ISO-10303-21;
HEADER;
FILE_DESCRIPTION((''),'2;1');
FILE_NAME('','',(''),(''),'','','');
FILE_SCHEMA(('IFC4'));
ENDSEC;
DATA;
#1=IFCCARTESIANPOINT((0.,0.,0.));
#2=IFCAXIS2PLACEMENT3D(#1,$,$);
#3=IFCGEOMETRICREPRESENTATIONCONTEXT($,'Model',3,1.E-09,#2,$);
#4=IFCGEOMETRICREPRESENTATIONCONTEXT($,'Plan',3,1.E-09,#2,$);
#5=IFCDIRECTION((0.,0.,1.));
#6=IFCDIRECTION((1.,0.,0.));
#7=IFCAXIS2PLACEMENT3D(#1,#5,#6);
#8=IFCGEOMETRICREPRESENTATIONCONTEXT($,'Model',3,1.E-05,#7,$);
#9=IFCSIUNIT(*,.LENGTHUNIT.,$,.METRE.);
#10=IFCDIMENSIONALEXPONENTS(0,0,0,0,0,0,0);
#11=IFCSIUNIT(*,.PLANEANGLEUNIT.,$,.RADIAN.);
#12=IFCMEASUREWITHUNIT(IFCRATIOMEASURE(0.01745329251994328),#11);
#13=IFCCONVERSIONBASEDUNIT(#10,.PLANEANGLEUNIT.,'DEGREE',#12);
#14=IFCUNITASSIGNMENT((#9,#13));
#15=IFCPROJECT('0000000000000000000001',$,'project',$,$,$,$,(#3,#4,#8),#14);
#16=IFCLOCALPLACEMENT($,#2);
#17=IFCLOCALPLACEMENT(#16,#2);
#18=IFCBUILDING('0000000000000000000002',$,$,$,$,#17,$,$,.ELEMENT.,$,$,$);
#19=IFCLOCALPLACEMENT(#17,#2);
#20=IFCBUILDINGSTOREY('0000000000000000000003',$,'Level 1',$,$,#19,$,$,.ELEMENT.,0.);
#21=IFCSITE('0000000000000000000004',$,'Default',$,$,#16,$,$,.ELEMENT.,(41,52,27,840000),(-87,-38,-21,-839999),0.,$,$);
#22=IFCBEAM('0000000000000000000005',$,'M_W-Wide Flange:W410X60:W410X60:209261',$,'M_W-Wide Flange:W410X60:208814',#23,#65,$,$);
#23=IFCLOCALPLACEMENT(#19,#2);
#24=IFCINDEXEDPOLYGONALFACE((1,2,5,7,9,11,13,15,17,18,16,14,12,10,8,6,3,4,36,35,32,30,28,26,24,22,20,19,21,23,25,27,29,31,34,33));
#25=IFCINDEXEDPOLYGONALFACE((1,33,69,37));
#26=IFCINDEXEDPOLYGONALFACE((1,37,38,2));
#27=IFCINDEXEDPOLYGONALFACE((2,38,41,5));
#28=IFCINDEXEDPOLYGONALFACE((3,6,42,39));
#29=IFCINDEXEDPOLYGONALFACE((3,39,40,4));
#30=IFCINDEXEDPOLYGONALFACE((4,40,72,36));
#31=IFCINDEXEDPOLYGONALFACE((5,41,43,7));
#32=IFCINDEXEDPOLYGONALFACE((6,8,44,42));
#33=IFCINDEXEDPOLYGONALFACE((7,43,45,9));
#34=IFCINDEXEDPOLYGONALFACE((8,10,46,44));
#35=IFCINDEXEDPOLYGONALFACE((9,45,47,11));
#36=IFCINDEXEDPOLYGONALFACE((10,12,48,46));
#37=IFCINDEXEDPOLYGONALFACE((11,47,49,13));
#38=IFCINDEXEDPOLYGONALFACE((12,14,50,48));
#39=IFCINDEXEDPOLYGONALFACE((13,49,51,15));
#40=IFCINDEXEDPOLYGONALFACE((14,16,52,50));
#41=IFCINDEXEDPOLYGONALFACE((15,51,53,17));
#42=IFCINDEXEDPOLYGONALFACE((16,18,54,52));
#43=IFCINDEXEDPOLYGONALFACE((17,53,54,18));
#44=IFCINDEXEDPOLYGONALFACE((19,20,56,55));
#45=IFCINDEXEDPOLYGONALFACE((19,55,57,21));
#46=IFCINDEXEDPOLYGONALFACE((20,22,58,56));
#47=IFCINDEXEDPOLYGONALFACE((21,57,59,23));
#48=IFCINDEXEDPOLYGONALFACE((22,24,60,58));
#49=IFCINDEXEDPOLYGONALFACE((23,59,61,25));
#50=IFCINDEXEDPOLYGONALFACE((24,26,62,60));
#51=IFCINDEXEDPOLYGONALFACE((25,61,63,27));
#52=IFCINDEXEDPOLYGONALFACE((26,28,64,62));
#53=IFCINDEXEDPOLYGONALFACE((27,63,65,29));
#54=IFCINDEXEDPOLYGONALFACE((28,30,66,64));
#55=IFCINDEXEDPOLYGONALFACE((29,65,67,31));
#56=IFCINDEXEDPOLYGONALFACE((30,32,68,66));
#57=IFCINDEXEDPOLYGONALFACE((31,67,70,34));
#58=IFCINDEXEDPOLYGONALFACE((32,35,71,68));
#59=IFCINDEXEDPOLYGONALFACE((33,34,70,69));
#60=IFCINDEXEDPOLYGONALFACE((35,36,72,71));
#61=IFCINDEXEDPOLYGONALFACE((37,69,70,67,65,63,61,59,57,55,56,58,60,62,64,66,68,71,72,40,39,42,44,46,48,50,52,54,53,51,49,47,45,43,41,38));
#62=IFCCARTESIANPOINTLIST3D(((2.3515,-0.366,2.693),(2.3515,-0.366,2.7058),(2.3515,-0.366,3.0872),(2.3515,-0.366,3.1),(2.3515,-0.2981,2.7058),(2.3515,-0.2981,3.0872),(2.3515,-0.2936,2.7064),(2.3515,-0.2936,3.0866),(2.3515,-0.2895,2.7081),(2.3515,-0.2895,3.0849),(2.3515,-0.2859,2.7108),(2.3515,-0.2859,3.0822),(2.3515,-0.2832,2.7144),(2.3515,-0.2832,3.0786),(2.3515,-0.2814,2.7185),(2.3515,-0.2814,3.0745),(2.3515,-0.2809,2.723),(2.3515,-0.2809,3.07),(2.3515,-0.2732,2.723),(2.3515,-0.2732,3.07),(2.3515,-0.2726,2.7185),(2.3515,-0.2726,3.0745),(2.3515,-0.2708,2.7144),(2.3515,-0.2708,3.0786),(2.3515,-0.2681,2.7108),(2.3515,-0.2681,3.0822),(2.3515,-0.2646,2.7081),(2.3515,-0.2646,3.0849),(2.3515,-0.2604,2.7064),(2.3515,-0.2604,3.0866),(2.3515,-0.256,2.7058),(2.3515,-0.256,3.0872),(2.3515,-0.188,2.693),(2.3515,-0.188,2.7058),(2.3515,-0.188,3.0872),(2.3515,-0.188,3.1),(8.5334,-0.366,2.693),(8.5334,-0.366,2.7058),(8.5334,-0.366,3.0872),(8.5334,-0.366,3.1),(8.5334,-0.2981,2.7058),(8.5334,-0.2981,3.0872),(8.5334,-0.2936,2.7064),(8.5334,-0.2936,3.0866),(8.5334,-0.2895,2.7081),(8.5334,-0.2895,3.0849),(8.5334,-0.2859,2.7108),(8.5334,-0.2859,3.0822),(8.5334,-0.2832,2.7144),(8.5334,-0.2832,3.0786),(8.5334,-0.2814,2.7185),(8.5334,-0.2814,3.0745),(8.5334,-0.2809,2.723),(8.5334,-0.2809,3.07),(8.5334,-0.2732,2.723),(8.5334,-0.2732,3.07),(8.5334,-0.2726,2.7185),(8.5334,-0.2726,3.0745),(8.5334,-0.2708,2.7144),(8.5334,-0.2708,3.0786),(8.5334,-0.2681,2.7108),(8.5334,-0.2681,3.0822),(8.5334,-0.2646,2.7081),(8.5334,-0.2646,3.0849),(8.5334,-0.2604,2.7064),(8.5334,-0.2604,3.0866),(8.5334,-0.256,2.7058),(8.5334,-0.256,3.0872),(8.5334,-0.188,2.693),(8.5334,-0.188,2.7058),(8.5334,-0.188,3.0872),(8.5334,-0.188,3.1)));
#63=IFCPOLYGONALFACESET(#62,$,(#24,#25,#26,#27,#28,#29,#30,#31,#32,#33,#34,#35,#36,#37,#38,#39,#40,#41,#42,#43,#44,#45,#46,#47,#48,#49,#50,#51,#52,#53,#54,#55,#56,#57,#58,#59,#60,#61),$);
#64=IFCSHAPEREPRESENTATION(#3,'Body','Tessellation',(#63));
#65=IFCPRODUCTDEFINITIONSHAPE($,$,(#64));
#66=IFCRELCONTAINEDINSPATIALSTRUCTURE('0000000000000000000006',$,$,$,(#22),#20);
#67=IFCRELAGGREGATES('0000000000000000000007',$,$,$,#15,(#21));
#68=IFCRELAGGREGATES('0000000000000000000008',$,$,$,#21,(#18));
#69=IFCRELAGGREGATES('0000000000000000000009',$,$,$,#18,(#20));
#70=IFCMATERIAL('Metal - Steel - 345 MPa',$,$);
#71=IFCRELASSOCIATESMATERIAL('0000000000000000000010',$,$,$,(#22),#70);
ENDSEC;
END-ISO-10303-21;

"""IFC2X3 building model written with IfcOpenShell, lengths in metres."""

from ifc_helpers import new_model, entity, si_unit, converted_unit, frame, frame_2d, origin, origin_with_axes, place, context, project, spatial, polyline, circle_curve, parameter, trimmed, segment, composite_curve, outline, extrude, material, element, save


model = new_model("IFC2X3")

# Units and contexts
model_context_1 = context("Model", 3, precision=1e-09, world=origin())
plan_context = context("Plan", 3, precision=1e-09, world=origin())
model_context_2 = context("Model", 3, precision=1e-05, world=origin_with_axes())
ifc_project = project(units=[si_unit("LENGTHUNIT", "METRE"), converted_unit("PLANEANGLEUNIT", "DEGREE", entity("IfcRatioMeasure", 0.01745329251994328), si_unit("PLANEANGLEUNIT", "RADIAN"), dimensions=[0, 0, 0, 0, 0, 0, 0])], contexts=[model_context_1, plan_context, model_context_2])

# Site, building, storey
site_placement = place(None, origin())
site = spatial("IfcSite", under=ifc_project, at=site_placement, Name="Default", CompositionType="ELEMENT", RefLatitude=(41, 52, 27, 840000), RefLongitude=(-87, -38, -21, -839999), RefElevation=0.0)
building_placement = place(site_placement, origin())
building = spatial("IfcBuilding", under=site, at=building_placement, CompositionType="ELEMENT")
storey_placement = place(building_placement, origin())
storey = spatial("IfcBuildingStorey", under=building, at=storey_placement, Name="Level 1", CompositionType="ELEMENT", Elevation=0.0)

# Beam
ifc_material_1 = material(Name="Metal - Steel - 345 MPa")
beam_placement = place(storey_placement, frame((8.5915, -0.277, 3.1), z_axis=(0.0, 0.0, 1.0), x_axis=(0.0, 1.0, 0.0)))
element("IfcBeam", 1, at=beam_placement, inside=storey, material=ifc_material_1, Name="M_W-Wide Flange:W410X60:W410X60:209261", ObjectType="M_W-Wide Flange:W410X60:208814", context=model_context_1, shape_type="SweptSolid", body=[
    extrude(outline(composite_curve([segment(polyline([(0.1907, -0.089), (0.2035, -0.089)]), True, "CONTINUOUS"), segment(polyline([(0.2035, -0.089), (0.2035, 0.089)]), True, "CONTINUOUS"), segment(polyline([(0.2035, 0.089), (0.1907, 0.089)]), True, "CONTINUOUS"), segment(polyline([(0.1907, 0.089), (0.1907, 0.021)]), True, "CONTINUOUS"), segment(trimmed(circle_curve(frame_2d((0.1735, 0.021), x_axis=(1.0, 0.0)), 0.0172), [parameter(270.0)], [parameter(360.0)], True, "PARAMETER"), False, "CONTINUOUS"), segment(polyline([(0.1735, 0.0038), (-0.1735, 0.0038)]), True, "CONTINUOUS"), segment(trimmed(circle_curve(frame_2d((-0.1735, 0.021), x_axis=(0.0, -1.0)), 0.0172), [parameter(270.0)], [parameter(360.0)], True, "PARAMETER"), False, "CONTINUOUS"), segment(polyline([(-0.1907, 0.021), (-0.1907, 0.089)]), True, "CONTINUOUS"), segment(polyline([(-0.1907, 0.089), (-0.2035, 0.089)]), True, "CONTINUOUS"), segment(polyline([(-0.2035, 0.089), (-0.2035, -0.089)]), True, "CONTINUOUS"), segment(polyline([(-0.2035, -0.089), (-0.1907, -0.089)]), True, "CONTINUOUS"), segment(polyline([(-0.1907, -0.089), (-0.1907, -0.0211)]), True, "CONTINUOUS"), segment(trimmed(circle_curve(frame_2d((-0.1735, -0.0211), x_axis=(-1.0, 0.0)), 0.0172), [parameter(270.0)], [parameter(0.0)], True, "PARAMETER"), False, "CONTINUOUS"), segment(polyline([(-0.1735, -0.0039), (0.1735, -0.0039)]), True, "CONTINUOUS"), segment(trimmed(circle_curve(frame_2d((0.1735, -0.0211), x_axis=(0.0, 1.0)), 0.0172), [parameter(270.0)], [parameter(0.0)], True, "PARAMETER"), False, "CONTINUOUS"), segment(polyline([(0.1907, -0.0211), (0.1907, -0.089)]), True, "CONTINUOUS")], self_intersect=False)), frame((0.0, 6.24, -0.2035), z_axis=(0.0, -1.0, 0.0), x_axis=(0.0, 0.0, -1.0)), (0.0, 0.0, 1.0), 6.1819),
])

save(model, "model.ifc")
